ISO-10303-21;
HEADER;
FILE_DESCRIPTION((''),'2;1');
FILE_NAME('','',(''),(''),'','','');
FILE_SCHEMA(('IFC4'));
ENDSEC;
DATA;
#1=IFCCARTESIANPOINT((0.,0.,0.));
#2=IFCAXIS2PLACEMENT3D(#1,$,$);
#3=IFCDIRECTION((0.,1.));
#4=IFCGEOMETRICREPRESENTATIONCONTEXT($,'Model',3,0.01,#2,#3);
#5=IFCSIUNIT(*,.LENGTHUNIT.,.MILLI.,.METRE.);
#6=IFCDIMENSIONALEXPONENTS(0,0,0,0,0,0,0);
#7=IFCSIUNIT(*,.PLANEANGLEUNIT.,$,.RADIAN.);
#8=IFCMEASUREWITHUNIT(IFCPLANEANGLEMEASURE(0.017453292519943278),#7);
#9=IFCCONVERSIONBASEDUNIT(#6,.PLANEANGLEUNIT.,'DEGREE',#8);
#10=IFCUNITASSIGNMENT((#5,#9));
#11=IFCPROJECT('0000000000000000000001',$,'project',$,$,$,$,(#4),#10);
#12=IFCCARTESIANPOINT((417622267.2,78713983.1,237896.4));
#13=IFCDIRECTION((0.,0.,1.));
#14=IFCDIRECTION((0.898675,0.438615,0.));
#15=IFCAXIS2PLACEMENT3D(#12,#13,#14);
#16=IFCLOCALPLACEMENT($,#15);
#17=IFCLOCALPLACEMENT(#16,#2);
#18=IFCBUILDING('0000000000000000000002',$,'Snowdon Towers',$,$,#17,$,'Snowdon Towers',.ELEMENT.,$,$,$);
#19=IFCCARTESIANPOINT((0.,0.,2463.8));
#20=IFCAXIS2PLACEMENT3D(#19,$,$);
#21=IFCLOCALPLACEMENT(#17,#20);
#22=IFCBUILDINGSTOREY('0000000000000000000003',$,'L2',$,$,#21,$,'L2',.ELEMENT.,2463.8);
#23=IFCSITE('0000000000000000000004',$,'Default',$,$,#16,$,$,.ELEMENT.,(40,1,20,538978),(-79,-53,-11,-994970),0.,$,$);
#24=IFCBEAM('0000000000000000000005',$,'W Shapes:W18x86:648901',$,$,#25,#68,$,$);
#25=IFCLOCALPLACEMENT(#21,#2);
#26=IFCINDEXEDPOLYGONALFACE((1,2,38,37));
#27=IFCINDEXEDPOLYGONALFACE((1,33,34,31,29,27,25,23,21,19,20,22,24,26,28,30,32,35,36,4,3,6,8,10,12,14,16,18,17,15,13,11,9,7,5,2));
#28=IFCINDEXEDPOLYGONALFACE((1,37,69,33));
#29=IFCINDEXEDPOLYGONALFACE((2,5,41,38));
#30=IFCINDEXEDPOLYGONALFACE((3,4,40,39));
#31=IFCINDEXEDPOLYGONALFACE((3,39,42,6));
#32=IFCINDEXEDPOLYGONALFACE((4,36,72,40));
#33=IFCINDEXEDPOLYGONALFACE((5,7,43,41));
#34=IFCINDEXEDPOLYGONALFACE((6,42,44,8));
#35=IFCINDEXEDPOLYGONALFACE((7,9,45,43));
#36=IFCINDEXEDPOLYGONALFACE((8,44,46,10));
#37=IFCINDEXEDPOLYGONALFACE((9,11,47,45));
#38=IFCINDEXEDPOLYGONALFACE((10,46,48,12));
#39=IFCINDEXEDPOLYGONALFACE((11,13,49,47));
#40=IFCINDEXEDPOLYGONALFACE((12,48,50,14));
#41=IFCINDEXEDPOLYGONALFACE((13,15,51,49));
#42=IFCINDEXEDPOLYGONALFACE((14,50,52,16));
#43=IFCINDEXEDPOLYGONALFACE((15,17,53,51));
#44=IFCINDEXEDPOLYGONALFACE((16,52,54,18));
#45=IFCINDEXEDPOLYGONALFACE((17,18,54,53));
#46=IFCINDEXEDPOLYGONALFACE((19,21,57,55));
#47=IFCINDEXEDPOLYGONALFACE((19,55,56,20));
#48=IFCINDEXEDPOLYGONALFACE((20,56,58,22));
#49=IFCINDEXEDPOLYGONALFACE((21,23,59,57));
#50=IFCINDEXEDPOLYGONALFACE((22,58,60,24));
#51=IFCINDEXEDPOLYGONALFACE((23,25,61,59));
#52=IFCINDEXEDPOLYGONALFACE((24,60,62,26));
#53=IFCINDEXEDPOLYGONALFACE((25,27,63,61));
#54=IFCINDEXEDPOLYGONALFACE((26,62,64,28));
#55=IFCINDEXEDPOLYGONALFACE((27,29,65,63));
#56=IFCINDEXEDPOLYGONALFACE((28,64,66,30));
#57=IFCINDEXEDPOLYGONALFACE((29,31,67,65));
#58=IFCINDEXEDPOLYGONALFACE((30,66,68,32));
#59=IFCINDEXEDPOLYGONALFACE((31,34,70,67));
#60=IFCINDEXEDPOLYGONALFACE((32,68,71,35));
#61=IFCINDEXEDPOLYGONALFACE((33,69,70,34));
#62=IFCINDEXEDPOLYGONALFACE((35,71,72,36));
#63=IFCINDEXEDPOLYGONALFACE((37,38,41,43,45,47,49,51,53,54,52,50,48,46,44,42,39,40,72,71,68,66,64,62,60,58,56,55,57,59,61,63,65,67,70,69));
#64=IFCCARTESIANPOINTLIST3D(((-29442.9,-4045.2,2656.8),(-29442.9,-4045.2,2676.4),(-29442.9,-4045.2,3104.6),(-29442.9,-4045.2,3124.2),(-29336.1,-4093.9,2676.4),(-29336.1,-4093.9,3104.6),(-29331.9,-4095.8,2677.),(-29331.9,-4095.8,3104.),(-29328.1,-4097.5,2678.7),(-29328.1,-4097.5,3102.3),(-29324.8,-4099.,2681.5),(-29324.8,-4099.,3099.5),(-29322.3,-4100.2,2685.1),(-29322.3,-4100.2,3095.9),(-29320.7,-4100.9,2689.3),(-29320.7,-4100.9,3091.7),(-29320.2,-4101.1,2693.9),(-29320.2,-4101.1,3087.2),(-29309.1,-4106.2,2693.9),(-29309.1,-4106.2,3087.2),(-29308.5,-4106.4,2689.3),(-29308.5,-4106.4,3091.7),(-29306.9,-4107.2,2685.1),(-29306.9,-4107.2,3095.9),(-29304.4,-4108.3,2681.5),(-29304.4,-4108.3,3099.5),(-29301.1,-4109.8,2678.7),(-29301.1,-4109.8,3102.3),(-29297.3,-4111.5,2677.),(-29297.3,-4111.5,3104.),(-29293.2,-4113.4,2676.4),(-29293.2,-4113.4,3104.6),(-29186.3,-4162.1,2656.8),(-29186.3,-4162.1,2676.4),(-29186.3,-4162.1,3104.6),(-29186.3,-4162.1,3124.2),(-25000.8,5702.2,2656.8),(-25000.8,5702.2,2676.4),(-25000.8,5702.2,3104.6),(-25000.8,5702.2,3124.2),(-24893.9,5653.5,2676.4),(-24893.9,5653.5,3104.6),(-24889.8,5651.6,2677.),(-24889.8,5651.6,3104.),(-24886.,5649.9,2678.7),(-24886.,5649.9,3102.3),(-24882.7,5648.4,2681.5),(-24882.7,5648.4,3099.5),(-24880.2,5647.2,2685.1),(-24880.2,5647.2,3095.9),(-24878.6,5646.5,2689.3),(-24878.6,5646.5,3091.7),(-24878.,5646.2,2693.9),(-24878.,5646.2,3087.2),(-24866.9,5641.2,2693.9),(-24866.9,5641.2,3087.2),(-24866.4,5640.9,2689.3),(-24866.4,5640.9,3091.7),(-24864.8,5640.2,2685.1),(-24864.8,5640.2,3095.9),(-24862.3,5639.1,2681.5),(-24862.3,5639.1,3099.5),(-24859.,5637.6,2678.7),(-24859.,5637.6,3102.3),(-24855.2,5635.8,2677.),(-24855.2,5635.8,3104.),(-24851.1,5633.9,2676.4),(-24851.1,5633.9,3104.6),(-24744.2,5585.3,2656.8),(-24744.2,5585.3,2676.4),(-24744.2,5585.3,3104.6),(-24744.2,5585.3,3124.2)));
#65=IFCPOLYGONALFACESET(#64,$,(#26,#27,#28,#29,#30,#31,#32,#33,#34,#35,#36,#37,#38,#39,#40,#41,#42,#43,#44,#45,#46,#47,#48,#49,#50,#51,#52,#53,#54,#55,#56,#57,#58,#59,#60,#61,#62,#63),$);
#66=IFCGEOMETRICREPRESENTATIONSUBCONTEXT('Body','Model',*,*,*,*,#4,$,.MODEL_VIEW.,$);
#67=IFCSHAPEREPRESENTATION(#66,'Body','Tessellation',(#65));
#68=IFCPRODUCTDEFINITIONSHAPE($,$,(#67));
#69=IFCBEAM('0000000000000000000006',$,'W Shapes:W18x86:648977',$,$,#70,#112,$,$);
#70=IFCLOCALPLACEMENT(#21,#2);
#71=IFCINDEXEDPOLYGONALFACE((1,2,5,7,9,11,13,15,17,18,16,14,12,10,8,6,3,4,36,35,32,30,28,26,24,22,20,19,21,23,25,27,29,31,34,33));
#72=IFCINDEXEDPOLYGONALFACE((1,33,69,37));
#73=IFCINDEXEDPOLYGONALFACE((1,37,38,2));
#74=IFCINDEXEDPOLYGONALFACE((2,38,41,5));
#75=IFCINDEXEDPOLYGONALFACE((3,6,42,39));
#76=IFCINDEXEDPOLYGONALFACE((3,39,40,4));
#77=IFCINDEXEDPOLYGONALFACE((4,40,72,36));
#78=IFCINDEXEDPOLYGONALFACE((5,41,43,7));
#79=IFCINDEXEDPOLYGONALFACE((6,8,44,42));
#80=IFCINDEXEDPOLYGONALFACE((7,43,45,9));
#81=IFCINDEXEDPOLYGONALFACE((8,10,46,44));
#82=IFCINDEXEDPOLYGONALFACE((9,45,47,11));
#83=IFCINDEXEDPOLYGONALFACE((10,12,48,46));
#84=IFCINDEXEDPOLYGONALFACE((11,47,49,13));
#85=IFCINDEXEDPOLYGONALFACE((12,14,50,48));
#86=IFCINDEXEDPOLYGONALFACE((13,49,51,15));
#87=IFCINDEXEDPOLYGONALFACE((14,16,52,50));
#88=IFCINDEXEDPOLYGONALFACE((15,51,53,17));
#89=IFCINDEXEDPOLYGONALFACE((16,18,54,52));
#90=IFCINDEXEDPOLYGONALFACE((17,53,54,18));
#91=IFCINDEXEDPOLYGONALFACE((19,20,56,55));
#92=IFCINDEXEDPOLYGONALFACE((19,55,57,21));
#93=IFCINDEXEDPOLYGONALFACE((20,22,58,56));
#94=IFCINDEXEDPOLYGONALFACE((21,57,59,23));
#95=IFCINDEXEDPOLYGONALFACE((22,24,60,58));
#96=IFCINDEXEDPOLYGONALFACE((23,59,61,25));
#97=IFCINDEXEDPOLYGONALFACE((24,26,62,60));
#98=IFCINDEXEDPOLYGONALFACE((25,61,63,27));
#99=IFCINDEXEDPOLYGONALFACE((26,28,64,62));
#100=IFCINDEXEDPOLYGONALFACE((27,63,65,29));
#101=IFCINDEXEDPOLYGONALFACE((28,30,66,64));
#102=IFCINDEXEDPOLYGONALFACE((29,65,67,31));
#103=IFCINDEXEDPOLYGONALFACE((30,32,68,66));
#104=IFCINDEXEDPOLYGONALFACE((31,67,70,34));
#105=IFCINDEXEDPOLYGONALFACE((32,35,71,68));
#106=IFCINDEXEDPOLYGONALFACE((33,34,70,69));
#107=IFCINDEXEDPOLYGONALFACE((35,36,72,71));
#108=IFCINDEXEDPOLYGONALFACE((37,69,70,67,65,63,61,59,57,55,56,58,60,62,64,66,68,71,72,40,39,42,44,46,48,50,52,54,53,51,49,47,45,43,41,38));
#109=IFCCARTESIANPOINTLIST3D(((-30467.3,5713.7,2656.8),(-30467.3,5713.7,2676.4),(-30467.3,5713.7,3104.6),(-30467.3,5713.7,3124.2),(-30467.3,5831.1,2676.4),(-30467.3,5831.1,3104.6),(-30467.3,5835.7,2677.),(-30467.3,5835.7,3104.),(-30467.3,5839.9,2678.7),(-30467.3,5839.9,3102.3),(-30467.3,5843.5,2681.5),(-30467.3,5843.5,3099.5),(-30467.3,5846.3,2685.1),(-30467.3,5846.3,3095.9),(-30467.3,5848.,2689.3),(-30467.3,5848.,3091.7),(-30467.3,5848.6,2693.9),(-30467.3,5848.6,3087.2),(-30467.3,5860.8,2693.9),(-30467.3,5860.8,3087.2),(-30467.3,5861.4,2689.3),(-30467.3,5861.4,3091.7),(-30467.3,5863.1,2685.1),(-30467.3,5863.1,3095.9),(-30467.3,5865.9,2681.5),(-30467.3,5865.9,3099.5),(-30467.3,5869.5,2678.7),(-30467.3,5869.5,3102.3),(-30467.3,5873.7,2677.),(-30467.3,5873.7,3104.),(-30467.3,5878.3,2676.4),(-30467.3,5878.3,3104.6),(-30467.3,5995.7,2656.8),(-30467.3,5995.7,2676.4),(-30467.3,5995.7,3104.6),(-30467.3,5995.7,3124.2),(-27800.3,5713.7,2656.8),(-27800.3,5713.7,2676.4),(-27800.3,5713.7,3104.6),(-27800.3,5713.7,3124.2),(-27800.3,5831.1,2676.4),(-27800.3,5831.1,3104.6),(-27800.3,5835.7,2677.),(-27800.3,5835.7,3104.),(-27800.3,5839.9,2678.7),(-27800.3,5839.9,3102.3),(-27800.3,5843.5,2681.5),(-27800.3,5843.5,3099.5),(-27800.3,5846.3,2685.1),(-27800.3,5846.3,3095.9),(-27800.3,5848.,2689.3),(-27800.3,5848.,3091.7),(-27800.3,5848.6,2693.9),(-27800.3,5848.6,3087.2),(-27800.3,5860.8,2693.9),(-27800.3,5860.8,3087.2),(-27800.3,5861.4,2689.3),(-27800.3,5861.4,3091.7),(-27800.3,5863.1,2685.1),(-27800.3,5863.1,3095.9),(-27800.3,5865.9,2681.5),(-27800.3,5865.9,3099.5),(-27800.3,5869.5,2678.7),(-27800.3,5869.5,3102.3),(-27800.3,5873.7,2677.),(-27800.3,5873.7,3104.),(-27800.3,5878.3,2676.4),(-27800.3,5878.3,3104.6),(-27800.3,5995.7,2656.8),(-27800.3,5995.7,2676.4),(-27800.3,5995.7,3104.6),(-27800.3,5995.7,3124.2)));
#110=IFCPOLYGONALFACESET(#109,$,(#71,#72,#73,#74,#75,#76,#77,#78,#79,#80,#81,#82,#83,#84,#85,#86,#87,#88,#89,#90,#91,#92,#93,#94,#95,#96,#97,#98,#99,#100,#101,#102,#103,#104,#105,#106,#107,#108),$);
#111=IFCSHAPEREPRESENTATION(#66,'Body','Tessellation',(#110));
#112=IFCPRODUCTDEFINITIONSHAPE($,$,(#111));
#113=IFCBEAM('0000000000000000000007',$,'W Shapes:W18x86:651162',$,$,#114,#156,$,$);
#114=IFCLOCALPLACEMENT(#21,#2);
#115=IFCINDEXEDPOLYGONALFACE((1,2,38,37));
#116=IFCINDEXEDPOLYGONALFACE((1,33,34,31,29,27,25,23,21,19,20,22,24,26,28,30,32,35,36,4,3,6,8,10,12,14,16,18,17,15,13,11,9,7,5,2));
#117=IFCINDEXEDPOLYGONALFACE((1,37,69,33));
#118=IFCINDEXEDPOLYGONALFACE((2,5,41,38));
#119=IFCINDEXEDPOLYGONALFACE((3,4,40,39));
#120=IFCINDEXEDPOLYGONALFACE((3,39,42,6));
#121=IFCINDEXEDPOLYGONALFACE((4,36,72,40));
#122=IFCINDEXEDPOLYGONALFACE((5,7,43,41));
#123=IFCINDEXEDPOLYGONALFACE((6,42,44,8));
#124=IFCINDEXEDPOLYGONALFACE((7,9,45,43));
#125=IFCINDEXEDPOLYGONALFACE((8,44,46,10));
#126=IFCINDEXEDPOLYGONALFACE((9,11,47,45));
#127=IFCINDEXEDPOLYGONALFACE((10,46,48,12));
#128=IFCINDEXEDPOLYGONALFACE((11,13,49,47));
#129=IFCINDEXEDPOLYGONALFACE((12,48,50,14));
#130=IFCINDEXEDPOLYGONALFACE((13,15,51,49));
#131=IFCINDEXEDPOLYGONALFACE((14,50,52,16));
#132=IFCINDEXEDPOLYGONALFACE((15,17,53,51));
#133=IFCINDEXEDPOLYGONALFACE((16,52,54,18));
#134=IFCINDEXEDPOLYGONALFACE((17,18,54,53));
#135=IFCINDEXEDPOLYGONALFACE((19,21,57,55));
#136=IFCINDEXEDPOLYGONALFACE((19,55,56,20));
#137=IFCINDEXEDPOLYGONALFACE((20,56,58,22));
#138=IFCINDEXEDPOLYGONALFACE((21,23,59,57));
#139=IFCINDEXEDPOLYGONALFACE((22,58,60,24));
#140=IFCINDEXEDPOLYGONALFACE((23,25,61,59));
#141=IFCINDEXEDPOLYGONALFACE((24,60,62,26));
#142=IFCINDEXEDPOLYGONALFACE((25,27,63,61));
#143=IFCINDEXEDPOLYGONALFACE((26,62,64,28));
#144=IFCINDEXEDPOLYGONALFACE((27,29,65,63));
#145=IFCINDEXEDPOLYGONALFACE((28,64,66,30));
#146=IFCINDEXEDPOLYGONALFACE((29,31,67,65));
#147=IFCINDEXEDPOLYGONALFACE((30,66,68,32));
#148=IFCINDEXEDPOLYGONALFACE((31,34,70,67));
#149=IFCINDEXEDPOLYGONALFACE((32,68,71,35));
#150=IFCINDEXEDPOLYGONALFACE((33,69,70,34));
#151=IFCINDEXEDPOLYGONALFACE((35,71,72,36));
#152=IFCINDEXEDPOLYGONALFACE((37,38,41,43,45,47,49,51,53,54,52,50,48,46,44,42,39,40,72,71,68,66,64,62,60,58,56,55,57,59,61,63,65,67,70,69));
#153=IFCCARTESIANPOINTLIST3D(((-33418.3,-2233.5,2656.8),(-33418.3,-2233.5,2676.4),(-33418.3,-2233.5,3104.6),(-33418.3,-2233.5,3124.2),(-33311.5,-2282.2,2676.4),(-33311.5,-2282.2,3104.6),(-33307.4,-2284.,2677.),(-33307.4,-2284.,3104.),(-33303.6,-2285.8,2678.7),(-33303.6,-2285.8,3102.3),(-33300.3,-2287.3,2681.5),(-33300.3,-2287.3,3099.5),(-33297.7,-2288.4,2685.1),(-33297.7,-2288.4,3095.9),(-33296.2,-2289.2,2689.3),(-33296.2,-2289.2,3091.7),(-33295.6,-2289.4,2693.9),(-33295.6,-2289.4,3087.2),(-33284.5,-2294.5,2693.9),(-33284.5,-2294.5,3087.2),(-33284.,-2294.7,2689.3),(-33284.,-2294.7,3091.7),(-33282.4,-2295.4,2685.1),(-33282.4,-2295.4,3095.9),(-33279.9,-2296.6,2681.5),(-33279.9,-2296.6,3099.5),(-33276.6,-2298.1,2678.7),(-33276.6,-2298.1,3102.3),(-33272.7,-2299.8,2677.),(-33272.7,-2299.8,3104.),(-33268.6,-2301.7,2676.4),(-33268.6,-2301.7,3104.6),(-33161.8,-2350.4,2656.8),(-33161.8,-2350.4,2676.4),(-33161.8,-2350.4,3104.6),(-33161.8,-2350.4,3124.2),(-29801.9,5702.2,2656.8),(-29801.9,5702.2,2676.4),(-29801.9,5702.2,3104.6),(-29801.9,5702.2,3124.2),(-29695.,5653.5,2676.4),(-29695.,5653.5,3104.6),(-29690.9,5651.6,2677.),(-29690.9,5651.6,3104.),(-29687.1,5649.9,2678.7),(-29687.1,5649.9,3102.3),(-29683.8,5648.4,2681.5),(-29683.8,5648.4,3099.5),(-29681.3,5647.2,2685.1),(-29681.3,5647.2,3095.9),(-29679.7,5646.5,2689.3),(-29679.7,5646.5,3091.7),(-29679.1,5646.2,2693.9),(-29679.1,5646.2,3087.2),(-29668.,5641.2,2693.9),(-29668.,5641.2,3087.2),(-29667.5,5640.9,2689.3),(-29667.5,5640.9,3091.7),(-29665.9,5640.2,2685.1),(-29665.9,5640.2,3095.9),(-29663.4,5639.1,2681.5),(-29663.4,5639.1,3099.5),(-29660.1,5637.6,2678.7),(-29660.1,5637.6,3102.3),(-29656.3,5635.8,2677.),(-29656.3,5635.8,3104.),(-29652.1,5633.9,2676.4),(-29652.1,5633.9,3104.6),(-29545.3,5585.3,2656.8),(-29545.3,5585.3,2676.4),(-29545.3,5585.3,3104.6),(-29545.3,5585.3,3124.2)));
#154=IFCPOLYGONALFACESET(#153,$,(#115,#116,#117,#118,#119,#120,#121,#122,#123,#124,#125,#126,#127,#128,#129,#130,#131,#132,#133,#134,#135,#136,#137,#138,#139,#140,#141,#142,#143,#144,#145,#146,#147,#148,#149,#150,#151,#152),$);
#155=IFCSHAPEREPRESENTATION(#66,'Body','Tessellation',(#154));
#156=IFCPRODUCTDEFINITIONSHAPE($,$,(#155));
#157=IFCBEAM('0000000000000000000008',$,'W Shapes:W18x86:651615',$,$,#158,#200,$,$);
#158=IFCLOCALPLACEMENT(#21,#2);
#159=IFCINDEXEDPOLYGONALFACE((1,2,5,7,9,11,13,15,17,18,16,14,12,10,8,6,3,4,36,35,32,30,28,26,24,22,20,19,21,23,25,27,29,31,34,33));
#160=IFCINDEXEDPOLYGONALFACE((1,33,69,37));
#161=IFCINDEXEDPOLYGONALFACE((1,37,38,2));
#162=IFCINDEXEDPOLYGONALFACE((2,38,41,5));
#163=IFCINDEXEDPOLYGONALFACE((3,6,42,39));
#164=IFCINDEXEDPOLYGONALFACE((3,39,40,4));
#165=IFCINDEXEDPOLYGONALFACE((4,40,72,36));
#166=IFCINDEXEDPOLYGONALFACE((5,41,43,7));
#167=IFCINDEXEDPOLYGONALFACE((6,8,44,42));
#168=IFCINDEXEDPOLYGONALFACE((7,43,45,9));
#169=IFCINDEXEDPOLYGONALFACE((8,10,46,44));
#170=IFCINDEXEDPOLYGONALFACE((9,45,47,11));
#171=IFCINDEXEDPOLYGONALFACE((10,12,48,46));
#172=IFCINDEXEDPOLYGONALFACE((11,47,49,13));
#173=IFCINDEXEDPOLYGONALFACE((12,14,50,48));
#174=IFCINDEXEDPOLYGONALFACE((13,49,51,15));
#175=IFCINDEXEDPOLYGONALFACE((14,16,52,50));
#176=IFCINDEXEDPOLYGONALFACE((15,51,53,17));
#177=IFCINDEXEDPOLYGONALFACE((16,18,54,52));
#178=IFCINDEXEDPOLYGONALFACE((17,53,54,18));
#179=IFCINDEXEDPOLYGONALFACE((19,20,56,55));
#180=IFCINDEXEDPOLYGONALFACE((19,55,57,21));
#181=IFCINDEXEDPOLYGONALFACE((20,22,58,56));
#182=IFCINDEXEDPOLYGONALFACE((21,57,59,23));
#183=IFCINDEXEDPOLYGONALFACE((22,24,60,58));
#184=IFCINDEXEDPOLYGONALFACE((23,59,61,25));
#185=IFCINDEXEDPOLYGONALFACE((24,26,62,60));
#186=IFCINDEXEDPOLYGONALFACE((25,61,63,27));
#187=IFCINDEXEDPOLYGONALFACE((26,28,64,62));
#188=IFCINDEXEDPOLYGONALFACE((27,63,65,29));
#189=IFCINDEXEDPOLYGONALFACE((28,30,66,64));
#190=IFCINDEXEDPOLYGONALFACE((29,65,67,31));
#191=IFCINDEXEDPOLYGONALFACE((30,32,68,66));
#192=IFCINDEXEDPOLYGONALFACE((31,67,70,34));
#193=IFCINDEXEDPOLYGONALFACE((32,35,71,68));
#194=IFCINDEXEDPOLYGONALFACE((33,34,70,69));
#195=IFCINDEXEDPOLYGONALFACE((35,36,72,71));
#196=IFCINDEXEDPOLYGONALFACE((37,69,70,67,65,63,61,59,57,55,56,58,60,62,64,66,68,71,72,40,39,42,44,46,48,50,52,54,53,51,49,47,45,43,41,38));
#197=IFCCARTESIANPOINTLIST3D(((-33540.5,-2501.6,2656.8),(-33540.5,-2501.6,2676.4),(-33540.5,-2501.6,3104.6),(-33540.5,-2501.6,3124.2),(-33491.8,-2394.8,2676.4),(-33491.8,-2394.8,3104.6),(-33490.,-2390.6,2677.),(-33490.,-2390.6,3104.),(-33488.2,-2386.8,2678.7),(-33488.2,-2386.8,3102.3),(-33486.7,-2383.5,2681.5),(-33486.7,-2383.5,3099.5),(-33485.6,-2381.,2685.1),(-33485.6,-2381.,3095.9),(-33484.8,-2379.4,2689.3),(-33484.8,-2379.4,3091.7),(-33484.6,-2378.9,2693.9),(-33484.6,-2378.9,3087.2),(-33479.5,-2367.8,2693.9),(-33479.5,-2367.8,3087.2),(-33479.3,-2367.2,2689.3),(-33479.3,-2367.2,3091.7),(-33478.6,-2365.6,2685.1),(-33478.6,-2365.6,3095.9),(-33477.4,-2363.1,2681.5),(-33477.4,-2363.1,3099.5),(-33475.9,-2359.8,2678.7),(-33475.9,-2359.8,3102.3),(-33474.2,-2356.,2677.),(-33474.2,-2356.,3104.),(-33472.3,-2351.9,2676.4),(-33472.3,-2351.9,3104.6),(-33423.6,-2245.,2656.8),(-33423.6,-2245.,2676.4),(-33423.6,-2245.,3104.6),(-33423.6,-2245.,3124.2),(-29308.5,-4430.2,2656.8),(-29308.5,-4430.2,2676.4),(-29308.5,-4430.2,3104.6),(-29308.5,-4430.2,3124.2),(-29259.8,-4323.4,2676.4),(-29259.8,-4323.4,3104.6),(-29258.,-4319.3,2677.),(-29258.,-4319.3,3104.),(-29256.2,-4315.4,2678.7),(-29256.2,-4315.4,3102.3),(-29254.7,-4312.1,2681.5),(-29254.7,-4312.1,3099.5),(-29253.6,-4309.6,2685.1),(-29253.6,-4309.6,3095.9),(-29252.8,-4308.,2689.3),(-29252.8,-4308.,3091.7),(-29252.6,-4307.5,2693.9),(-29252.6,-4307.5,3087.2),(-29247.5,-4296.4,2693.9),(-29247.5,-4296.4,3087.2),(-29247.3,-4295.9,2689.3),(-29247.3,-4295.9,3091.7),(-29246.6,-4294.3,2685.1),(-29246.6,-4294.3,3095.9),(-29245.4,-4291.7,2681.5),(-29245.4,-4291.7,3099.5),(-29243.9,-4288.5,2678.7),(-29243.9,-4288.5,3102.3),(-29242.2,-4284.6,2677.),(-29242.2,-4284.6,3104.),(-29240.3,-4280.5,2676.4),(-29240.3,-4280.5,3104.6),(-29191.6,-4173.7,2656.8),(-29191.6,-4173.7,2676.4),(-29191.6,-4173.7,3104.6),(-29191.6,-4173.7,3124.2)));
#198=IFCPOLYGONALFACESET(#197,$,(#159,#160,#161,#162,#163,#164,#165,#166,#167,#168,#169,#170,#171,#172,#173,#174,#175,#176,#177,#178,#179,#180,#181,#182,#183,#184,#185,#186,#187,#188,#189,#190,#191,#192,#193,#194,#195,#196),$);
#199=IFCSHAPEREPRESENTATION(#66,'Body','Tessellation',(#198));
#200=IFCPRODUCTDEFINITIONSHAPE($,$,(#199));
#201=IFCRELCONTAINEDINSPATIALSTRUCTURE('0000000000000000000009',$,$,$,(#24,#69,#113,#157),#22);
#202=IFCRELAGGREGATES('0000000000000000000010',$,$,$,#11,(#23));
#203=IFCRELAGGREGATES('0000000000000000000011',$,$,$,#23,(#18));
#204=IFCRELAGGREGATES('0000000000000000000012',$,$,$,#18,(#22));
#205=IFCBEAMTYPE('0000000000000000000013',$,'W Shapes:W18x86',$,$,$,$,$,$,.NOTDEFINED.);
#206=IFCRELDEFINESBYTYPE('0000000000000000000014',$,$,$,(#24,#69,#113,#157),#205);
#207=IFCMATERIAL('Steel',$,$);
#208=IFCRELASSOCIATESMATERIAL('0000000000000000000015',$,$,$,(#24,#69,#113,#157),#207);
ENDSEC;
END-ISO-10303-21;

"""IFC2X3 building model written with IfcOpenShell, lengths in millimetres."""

from ifc_helpers import new_model, entity, si_unit, converted_unit, direction, frame, frame_2d, origin, place, context, subcontext, project, spatial, i_section, extrude, material, type_object, element, save


model = new_model("IFC2X3")

# Units and contexts
model_context = context("Model", 3, precision=0.01, world=origin(), true_north=direction((0.0, 1.0)))
body_context = subcontext(model_context, "Body", "Model", "MODEL_VIEW")
ifc_project = project(units=[si_unit("LENGTHUNIT", "METRE", prefix="MILLI"), converted_unit("PLANEANGLEUNIT", "DEGREE", entity("IfcPlaneAngleMeasure", 0.017453292519943278), si_unit("PLANEANGLEUNIT", "RADIAN"), dimensions=[0, 0, 0, 0, 0, 0, 0])], contexts=[model_context])

# Site, building, storey
site_placement = place(None, frame((417622267.2, 78713983.1, 237896.4), z_axis=(0.0, 0.0, 1.0), x_axis=(0.898675, 0.438615, 0.0)))
site = spatial("IfcSite", under=ifc_project, at=site_placement, Name="Default", CompositionType="ELEMENT", RefLatitude=(40, 1, 20, 538978), RefLongitude=(-79, -53, -11, -994970), RefElevation=0.0)
building_placement = place(site_placement, origin())
building = spatial("IfcBuilding", under=site, at=building_placement, Name="Snowdon Towers", LongName="Snowdon Towers", CompositionType="ELEMENT")
storey_placement = place(building_placement, frame((0.0, 0.0, 2463.8)))
storey = spatial("IfcBuildingStorey", under=building, at=storey_placement, Name="L2", LongName="L2", CompositionType="ELEMENT", Elevation=2463.8)

# Beams
ifc_material = material(Name="Steel")
beam_type_1 = type_object("IfcBeamType", Name="W Shapes:W18x86", PredefinedType="NOTDEFINED")
beam_1_placement = place(storey_placement, frame((-29378.3, -4243.5, 3124.2), z_axis=(0.0, 0.0, 1.0), x_axis=(0.414693, 0.909961, 0.0)))
element("IfcBeam", 1, at=beam_1_placement, inside=storey, type_object=beam_type_1, material=ifc_material, Name="W Shapes:W18x86:648901", context=body_context, shape_type="SweptSolid", body=[
    extrude(i_section(OverallWidth=281.9, OverallDepth=467.4, WebThickness=12.2, FlangeThickness=19.6, FilletRadius=17.5, at=frame_2d((0.0, 0.0), x_axis=(0.0, 1.0))), frame((153.7, 0.0, -233.7), z_axis=(1.0, 0.0, 0.0), x_axis=(0.0, 0.0, -1.0)), (0.0, 0.0, 1.0), 10711.8),
])
beam_2_placement = place(storey_placement, frame((-30467.3, 5854.7, 3124.2)))
element("IfcBeam", 2, at=beam_2_placement, inside=storey, type_object=beam_type_1, material=ifc_material, Name="W Shapes:W18x86:648977", context=body_context, shape_type="SweptSolid", body=[
    extrude(i_section(OverallWidth=281.9, OverallDepth=467.4, WebThickness=12.2, FlangeThickness=19.6, FilletRadius=17.5, at=frame_2d((0.0, 0.0), x_axis=(0.0, 1.0))), frame((0.0, 0.0, -233.7), z_axis=(1.0, 0.0, 0.0), x_axis=(0.0, 0.0, -1.0)), (0.0, 0.0, 1.0), 2667.0),
])
beam_3_placement = place(storey_placement, frame((-33353.8, -2431.8, 3124.2), z_axis=(0.0, 0.0, 1.0), x_axis=(0.414693, 0.909961, 0.0)))
element("IfcBeam", 3, at=beam_3_placement, inside=storey, type_object=beam_type_1, material=ifc_material, Name="W Shapes:W18x86:651162", context=body_context, shape_type="SweptSolid", body=[
    extrude(i_section(OverallWidth=281.9, OverallDepth=467.4, WebThickness=12.2, FlangeThickness=19.6, FilletRadius=17.5, at=frame_2d((0.0, 0.0), x_axis=(0.0, 1.0))), frame((153.7, 0.0, -233.7), z_axis=(1.0, 0.0, 0.0), x_axis=(0.0, 0.0, -1.0)), (0.0, 0.0, 1.0), 8720.9),
])
beam_4_placement = place(storey_placement, frame((-33353.8, -2431.8, 3124.2), z_axis=(0.0, 0.0, 1.0), x_axis=(0.909961, -0.414693, 0.0)))
element("IfcBeam", 4, at=beam_4_placement, inside=storey, type_object=beam_type_1, material=ifc_material, Name="W Shapes:W18x86:651615", context=body_context, shape_type="SweptSolid", body=[
    extrude(i_section(OverallWidth=281.9, OverallDepth=467.4, WebThickness=12.2, FlangeThickness=19.6, FilletRadius=17.5, at=frame_2d((0.0, 0.0), x_axis=(0.0, 1.0))), frame((-141.0, 0.0, -233.7), z_axis=(1.0, 0.0, 0.0), x_axis=(0.0, 0.0, -1.0)), (0.0, 0.0, 1.0), 4650.7),
])

save(model, "model.ifc")
